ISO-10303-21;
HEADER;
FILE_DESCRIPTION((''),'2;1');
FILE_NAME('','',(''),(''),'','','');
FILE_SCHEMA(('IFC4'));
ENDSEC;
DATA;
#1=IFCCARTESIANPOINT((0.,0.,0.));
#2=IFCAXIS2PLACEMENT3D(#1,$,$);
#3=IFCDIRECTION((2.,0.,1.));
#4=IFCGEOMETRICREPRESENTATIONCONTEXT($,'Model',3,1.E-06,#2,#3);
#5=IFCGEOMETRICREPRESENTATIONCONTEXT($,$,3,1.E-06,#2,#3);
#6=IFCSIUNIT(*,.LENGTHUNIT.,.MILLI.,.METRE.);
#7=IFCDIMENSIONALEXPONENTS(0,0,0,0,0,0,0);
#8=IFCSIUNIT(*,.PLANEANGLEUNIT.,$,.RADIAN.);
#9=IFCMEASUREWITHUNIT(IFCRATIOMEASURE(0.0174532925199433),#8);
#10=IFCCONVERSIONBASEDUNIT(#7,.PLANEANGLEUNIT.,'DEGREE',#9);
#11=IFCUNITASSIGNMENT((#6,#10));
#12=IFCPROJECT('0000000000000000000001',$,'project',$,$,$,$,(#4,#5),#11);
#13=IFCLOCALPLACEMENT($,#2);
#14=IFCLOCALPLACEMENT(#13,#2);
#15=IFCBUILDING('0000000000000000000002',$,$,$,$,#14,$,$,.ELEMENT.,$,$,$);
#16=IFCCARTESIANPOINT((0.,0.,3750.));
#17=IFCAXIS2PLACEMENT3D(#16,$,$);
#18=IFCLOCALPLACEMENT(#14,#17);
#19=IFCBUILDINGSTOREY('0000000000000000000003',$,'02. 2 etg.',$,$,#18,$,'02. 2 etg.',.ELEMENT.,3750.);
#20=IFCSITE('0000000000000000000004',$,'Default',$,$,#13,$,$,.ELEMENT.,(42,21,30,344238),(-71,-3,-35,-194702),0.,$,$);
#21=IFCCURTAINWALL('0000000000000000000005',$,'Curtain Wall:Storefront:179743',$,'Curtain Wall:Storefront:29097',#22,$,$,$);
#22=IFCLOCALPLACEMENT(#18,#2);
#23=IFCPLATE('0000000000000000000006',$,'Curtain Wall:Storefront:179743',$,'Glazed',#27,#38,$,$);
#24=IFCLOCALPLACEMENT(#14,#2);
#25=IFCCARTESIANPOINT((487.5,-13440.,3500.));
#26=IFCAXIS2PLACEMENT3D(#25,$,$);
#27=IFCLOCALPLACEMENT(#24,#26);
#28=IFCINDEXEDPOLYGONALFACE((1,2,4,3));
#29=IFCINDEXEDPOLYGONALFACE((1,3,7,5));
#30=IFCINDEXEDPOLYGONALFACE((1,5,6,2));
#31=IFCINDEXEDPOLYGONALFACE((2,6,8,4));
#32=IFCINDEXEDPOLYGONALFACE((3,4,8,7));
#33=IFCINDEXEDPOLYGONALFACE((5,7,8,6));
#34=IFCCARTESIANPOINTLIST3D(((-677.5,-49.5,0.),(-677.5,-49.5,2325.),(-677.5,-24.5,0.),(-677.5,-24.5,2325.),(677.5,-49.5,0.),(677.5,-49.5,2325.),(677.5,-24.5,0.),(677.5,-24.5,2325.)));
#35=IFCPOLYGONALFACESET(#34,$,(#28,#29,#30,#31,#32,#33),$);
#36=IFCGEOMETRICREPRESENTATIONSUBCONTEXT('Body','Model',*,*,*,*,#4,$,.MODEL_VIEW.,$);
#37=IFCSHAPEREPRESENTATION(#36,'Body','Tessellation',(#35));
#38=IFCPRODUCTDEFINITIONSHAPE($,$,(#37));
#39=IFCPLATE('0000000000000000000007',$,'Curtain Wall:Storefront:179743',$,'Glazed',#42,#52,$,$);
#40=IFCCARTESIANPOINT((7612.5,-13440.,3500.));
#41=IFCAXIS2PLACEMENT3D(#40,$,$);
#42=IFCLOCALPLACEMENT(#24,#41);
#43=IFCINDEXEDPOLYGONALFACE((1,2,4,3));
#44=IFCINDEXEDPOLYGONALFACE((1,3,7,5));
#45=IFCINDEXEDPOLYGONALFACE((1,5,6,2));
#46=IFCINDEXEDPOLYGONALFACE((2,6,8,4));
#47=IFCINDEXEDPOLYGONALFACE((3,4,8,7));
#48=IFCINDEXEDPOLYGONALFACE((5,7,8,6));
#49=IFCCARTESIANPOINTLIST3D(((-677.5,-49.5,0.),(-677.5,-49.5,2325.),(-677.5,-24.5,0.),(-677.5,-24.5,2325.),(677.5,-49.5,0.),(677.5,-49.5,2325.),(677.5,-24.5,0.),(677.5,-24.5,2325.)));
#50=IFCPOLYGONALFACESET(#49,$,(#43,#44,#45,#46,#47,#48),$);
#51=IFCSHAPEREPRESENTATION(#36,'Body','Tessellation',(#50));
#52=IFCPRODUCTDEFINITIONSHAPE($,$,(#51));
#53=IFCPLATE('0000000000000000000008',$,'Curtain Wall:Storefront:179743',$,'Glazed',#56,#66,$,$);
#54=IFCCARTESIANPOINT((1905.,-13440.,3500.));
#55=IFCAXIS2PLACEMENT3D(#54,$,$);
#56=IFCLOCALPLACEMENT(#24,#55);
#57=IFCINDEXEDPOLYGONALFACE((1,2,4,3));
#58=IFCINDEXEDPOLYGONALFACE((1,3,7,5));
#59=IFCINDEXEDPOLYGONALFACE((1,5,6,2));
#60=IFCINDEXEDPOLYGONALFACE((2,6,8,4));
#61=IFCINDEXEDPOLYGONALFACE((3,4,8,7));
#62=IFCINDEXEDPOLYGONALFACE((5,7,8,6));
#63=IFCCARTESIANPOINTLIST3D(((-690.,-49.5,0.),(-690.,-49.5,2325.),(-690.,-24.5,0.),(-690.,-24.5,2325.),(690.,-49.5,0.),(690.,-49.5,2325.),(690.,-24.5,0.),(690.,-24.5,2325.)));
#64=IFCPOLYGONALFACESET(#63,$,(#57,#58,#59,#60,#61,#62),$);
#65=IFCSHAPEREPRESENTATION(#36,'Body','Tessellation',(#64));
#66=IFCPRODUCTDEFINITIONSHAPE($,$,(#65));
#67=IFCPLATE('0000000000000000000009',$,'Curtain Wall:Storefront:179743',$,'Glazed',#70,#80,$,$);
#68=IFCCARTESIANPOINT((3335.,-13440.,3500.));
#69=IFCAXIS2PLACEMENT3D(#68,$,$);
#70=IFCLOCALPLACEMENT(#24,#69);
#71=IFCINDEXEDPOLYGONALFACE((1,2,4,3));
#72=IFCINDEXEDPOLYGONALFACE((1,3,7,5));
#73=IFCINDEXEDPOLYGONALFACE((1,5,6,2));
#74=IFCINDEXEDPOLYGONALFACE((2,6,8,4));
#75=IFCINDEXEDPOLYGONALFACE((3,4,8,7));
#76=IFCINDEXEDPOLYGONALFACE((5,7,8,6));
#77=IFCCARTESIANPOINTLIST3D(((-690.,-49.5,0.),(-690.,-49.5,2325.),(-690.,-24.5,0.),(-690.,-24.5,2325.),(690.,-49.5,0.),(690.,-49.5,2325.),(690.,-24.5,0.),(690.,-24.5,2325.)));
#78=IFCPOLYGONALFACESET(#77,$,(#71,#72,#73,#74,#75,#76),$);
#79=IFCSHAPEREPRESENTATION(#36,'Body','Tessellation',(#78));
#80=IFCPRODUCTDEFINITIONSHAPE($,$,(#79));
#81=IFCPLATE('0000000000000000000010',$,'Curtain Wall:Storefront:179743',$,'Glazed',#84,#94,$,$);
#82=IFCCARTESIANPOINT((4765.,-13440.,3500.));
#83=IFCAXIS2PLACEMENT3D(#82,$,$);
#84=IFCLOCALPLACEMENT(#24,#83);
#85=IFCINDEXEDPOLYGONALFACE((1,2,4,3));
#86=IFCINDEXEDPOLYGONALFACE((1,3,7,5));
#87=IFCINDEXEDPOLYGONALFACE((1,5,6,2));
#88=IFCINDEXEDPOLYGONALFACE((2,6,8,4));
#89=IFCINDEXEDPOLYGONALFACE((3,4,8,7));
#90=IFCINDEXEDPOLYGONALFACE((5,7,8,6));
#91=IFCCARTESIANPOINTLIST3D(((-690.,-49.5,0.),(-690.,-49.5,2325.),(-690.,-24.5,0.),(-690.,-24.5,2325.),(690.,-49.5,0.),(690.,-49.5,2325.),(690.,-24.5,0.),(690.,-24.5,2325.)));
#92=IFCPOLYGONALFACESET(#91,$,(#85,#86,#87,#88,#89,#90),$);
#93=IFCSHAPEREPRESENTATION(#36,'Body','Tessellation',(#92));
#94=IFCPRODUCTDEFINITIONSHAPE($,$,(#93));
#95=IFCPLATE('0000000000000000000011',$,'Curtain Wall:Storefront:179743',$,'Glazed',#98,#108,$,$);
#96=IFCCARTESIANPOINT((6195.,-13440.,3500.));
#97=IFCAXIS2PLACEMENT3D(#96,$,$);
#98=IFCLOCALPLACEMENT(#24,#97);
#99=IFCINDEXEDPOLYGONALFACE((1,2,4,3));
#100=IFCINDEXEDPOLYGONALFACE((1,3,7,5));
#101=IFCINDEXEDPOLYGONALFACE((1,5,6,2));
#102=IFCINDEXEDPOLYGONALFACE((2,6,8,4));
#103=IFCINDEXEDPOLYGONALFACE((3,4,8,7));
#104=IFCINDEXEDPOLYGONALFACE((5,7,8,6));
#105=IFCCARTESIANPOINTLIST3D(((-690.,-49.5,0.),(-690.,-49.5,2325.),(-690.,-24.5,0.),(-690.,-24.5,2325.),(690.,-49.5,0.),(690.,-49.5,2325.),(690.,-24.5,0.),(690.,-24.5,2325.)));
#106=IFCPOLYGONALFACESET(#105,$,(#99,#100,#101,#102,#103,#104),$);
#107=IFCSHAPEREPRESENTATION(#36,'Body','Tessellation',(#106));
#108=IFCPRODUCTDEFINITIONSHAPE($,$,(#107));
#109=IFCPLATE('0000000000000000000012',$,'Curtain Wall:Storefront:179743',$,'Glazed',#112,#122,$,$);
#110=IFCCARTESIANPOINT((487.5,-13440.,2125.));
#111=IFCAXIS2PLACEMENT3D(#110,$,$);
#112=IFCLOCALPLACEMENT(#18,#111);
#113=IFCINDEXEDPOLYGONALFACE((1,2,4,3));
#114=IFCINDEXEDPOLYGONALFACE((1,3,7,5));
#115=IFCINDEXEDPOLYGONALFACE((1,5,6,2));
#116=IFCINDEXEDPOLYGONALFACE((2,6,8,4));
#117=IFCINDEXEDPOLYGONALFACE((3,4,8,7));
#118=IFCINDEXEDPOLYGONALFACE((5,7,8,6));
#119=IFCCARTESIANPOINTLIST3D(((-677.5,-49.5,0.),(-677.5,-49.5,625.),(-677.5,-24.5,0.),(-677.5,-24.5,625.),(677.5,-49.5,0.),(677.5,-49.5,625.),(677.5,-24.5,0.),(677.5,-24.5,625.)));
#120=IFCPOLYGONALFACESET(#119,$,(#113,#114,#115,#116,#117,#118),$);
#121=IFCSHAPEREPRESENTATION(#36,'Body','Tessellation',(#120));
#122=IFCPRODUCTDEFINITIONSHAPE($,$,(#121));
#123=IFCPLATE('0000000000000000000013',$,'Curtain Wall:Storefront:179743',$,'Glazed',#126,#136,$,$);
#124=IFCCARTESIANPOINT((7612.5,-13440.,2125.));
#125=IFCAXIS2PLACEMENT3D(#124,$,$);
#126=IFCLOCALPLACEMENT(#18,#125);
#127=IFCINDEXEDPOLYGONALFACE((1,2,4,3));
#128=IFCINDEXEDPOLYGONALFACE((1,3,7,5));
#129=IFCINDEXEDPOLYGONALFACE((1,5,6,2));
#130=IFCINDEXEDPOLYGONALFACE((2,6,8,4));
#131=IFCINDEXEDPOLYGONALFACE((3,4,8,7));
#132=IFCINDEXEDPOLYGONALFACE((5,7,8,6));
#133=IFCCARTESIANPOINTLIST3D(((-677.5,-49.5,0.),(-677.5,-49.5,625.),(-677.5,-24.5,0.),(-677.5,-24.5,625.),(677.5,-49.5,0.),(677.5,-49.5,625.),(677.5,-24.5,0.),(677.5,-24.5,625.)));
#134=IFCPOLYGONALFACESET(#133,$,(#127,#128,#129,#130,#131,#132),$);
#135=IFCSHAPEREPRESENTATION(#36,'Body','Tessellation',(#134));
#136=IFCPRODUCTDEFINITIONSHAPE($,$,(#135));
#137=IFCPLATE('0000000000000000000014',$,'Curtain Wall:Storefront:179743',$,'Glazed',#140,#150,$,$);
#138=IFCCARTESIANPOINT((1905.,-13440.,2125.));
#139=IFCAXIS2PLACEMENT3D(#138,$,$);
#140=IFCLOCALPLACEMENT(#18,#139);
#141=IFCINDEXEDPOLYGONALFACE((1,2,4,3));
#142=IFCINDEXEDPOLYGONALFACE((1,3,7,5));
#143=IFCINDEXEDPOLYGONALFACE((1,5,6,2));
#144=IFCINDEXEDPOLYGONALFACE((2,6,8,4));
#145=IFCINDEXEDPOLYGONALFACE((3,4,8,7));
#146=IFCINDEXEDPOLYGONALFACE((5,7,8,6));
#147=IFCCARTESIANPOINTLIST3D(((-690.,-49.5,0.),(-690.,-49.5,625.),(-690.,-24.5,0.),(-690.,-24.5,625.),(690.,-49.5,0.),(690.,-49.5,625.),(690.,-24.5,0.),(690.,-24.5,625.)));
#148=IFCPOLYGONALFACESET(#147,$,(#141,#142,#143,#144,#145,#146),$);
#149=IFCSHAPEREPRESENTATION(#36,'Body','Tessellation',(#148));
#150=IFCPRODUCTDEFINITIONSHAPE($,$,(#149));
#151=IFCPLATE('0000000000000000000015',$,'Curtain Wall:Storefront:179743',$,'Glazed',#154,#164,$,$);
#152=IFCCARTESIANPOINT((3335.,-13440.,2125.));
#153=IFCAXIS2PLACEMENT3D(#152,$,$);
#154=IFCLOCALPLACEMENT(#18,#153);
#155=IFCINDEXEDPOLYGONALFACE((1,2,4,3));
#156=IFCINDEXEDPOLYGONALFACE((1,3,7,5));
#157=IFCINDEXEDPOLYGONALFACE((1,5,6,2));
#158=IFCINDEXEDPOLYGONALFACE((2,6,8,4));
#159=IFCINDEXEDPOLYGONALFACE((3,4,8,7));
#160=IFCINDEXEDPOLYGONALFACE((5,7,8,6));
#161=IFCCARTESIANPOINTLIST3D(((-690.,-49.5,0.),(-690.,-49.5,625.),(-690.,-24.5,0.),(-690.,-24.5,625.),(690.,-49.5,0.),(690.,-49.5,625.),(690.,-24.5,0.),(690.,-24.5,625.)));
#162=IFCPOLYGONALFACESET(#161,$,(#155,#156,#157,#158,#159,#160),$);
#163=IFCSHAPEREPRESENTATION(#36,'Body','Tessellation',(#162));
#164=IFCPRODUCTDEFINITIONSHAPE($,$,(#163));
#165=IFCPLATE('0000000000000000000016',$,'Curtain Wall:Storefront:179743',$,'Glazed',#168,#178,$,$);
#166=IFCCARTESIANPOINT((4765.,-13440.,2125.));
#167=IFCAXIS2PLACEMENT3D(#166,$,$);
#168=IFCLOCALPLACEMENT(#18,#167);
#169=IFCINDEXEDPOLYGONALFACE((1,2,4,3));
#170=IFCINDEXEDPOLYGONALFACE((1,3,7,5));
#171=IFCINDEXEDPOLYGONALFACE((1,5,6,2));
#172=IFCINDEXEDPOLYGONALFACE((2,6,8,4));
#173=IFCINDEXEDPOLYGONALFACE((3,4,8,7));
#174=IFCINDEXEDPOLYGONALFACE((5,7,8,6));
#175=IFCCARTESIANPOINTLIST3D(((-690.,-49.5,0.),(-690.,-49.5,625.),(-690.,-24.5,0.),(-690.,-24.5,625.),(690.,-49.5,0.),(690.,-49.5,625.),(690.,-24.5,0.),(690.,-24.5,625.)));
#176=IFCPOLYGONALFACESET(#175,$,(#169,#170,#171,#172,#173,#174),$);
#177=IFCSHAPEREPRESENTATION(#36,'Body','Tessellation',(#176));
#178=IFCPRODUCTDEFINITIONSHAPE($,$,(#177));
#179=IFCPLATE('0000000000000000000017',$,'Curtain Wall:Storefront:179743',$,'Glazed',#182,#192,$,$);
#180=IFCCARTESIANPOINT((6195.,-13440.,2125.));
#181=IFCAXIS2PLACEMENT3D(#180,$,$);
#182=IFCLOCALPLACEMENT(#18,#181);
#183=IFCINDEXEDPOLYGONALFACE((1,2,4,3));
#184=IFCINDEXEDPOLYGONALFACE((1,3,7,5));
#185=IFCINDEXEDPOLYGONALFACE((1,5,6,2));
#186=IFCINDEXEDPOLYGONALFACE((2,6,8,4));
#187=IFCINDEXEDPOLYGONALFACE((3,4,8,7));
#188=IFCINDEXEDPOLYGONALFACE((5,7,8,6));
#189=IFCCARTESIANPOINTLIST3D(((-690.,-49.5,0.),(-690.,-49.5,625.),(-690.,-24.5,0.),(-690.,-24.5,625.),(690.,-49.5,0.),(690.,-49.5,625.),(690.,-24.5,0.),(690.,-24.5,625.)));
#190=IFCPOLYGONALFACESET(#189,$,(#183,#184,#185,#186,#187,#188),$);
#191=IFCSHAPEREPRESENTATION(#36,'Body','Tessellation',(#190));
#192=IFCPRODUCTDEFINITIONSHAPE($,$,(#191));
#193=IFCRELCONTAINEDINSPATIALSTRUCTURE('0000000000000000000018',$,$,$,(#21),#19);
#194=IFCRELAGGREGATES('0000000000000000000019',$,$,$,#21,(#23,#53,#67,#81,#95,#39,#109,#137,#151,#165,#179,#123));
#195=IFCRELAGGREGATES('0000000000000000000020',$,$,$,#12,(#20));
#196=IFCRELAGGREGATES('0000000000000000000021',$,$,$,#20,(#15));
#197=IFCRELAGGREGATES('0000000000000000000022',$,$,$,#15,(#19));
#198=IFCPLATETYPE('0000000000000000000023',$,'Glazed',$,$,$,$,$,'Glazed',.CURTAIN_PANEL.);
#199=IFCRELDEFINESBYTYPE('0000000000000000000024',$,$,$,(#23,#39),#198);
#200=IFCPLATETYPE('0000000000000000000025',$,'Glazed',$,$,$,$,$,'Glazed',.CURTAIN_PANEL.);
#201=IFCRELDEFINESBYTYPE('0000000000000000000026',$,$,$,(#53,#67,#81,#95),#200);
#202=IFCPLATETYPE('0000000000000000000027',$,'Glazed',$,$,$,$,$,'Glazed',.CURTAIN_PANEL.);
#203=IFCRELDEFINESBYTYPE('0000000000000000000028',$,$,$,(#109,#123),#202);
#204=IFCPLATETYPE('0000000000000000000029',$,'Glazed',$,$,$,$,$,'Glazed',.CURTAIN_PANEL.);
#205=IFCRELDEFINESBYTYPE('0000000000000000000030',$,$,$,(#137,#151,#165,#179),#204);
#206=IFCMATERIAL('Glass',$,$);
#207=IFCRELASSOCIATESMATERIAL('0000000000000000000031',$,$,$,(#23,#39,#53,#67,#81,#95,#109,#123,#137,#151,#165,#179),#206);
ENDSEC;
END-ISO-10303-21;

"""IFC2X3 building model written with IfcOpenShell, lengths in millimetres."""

from ifc_helpers import new_model, entity, si_unit, converted_unit, direction, frame, frame_2d, origin, place, context, subcontext, project, spatial, rectangle, extrude, source, transform, mapped, material, type_object, type_shapes, element, aggregate, save


model = new_model("IFC2X3")

# Units and contexts
model_context = context("Model", 3, precision=1e-06, world=origin(), true_north=direction((2.0, 0.0, 1.0)))
context_of_model = context(None, 3, precision=1e-06, world=origin(), true_north=direction((2.0, 0.0, 1.0)))
body_context = subcontext(model_context, "Body", "Model", "MODEL_VIEW")
ifc_project = project(units=[si_unit("LENGTHUNIT", "METRE", prefix="MILLI"), converted_unit("PLANEANGLEUNIT", "DEGREE", entity("IfcRatioMeasure", 0.0174532925199433), si_unit("PLANEANGLEUNIT", "RADIAN"), dimensions=[0, 0, 0, 0, 0, 0, 0])], contexts=[model_context, context_of_model])

# Site, building, storey
site_placement = place(None, origin())
site = spatial("IfcSite", under=ifc_project, at=site_placement, Name="Default", CompositionType="ELEMENT", RefLatitude=(42, 21, 30, 344238), RefLongitude=(-71, -3, -35, -194702), RefElevation=0.0)
building_placement = place(site_placement, origin())
building = spatial("IfcBuilding", under=site, at=building_placement, CompositionType="ELEMENT")
storey_placement = place(building_placement, frame((0.0, 0.0, 3750.0)))
storey = spatial("IfcBuildingStorey", under=building, at=storey_placement, Name="02. 2 etg.", LongName="02. 2 etg.", CompositionType="ELEMENT", Elevation=3750.0)

# Curtain wall, plates
curtain_wall_1_placement = place(storey_placement, origin())
curtain_wall_1 = element("IfcCurtainWall", 1, at=curtain_wall_1_placement, inside=storey, Name="Curtain Wall:Storefront:179743", ObjectType="Curtain Wall:Storefront:29097")
ifc_material_1 = material(Name="Glass")
plate_type_1 = type_object("IfcPlateType", Name="Glazed", ElementType="Glazed", PredefinedType="CURTAIN_PANEL")
shared_shape_1 = source(origin(), body_context, "Body", "SweptSolid", [
    extrude(rectangle(XDim=25.0, YDim=1355.0, at=frame_2d((0.0, 0.0), x_axis=(1.0, 0.0))), frame((0.0, -37.0, 0.0), z_axis=(0.0, 0.0, 1.0), x_axis=(0.0, 1.0, 0.0)), (0.0, 0.0, 1.0), 2325.0),
])
type_shapes(plate_type_1, [shared_shape_1])
placement = place(building_placement, origin())
plate_1_placement = place(placement, frame((487.5, -13440.0, 3500.0)))
plate_1 = element("IfcPlate", 2, at=plate_1_placement, type_object=plate_type_1, material=ifc_material_1, Name="Curtain Wall:Storefront:179743", ObjectType="Glazed", context=body_context, shape_type="MappedRepresentation", body=[
    mapped(shared_shape_1, transform((0.0, 0.0, 0.0), scale=1.0)),
])
plate_2_placement = place(placement, frame((7612.5, -13440.0, 3500.0)))
plate_2 = element("IfcPlate", 3, at=plate_2_placement, type_object=plate_type_1, material=ifc_material_1, Name="Curtain Wall:Storefront:179743", ObjectType="Glazed", context=body_context, shape_type="MappedRepresentation", body=[
    mapped(shared_shape_1, transform((0.0, 0.0, 0.0), scale=1.0)),
])
plate_type_2 = type_object("IfcPlateType", Name="Glazed", ElementType="Glazed", PredefinedType="CURTAIN_PANEL")
shared_shape_2 = source(origin(), body_context, "Body", "SweptSolid", [
    extrude(rectangle(XDim=25.0, YDim=1380.0, at=frame_2d((0.0, 0.0), x_axis=(1.0, 0.0))), frame((0.0, -37.0, 0.0), z_axis=(0.0, 0.0, 1.0), x_axis=(0.0, 1.0, 0.0)), (0.0, 0.0, 1.0), 2325.0),
])
type_shapes(plate_type_2, [shared_shape_2])
plate_3_placement = place(placement, frame((1905.0, -13440.0, 3500.0)))
plate_3 = element("IfcPlate", 4, at=plate_3_placement, type_object=plate_type_2, material=ifc_material_1, Name="Curtain Wall:Storefront:179743", ObjectType="Glazed", context=body_context, shape_type="MappedRepresentation", body=[
    mapped(shared_shape_2, transform((0.0, 0.0, 0.0), scale=1.0)),
])
plate_4_placement = place(placement, frame((3335.0, -13440.0, 3500.0)))
plate_4 = element("IfcPlate", 5, at=plate_4_placement, type_object=plate_type_2, material=ifc_material_1, Name="Curtain Wall:Storefront:179743", ObjectType="Glazed", context=body_context, shape_type="MappedRepresentation", body=[
    mapped(shared_shape_2, transform((0.0, 0.0, 0.0), scale=1.0)),
])
plate_5_placement = place(placement, frame((4765.0, -13440.0, 3500.0)))
plate_5 = element("IfcPlate", 6, at=plate_5_placement, type_object=plate_type_2, material=ifc_material_1, Name="Curtain Wall:Storefront:179743", ObjectType="Glazed", context=body_context, shape_type="MappedRepresentation", body=[
    mapped(shared_shape_2, transform((0.0, 0.0, 0.0), scale=1.0)),
])
plate_6_placement = place(placement, frame((6195.0, -13440.0, 3500.0)))
plate_6 = element("IfcPlate", 7, at=plate_6_placement, type_object=plate_type_2, material=ifc_material_1, Name="Curtain Wall:Storefront:179743", ObjectType="Glazed", context=body_context, shape_type="MappedRepresentation", body=[
    mapped(shared_shape_2, transform((0.0, 0.0, 0.0), scale=1.0)),
])
plate_type_3 = type_object("IfcPlateType", Name="Glazed", ElementType="Glazed", PredefinedType="CURTAIN_PANEL")
shared_shape_3 = source(origin(), body_context, "Body", "SweptSolid", [
    extrude(rectangle(XDim=25.0, YDim=1355.0, at=frame_2d((0.0, 0.0), x_axis=(1.0, 0.0))), frame((0.0, -37.0, 0.0), z_axis=(0.0, 0.0, 1.0), x_axis=(0.0, 1.0, 0.0)), (0.0, 0.0, 1.0), 625.0),
])
type_shapes(plate_type_3, [shared_shape_3])
plate_7_placement = place(storey_placement, frame((487.5, -13440.0, 2125.0)))
plate_7 = element("IfcPlate", 8, at=plate_7_placement, type_object=plate_type_3, material=ifc_material_1, Name="Curtain Wall:Storefront:179743", ObjectType="Glazed", context=body_context, shape_type="MappedRepresentation", body=[
    mapped(shared_shape_3, transform((0.0, 0.0, 0.0), scale=1.0)),
])
plate_8_placement = place(storey_placement, frame((7612.5, -13440.0, 2125.0)))
plate_8 = element("IfcPlate", 9, at=plate_8_placement, type_object=plate_type_3, material=ifc_material_1, Name="Curtain Wall:Storefront:179743", ObjectType="Glazed", context=body_context, shape_type="MappedRepresentation", body=[
    mapped(shared_shape_3, transform((0.0, 0.0, 0.0), scale=1.0)),
])
plate_type_4 = type_object("IfcPlateType", Name="Glazed", ElementType="Glazed", PredefinedType="CURTAIN_PANEL")
shared_shape_4 = source(origin(), body_context, "Body", "SweptSolid", [
    extrude(rectangle(XDim=25.0, YDim=1380.0, at=frame_2d((0.0, 0.0), x_axis=(1.0, 0.0))), frame((0.0, -37.0, 0.0), z_axis=(0.0, 0.0, 1.0), x_axis=(0.0, 1.0, 0.0)), (0.0, 0.0, 1.0), 625.0),
])
type_shapes(plate_type_4, [shared_shape_4])
plate_9_placement = place(storey_placement, frame((1905.0, -13440.0, 2125.0)))
plate_9 = element("IfcPlate", 10, at=plate_9_placement, type_object=plate_type_4, material=ifc_material_1, Name="Curtain Wall:Storefront:179743", ObjectType="Glazed", context=body_context, shape_type="MappedRepresentation", body=[
    mapped(shared_shape_4, transform((0.0, 0.0, 0.0), scale=1.0)),
])
plate_10_placement = place(storey_placement, frame((3335.0, -13440.0, 2125.0)))
plate_10 = element("IfcPlate", 11, at=plate_10_placement, type_object=plate_type_4, material=ifc_material_1, Name="Curtain Wall:Storefront:179743", ObjectType="Glazed", context=body_context, shape_type="MappedRepresentation", body=[
    mapped(shared_shape_4, transform((0.0, 0.0, 0.0), scale=1.0)),
])
plate_11_placement = place(storey_placement, frame((4765.0, -13440.0, 2125.0)))
plate_11 = element("IfcPlate", 12, at=plate_11_placement, type_object=plate_type_4, material=ifc_material_1, Name="Curtain Wall:Storefront:179743", ObjectType="Glazed", context=body_context, shape_type="MappedRepresentation", body=[
    mapped(shared_shape_4, transform((0.0, 0.0, 0.0), scale=1.0)),
])
plate_12_placement = place(storey_placement, frame((6195.0, -13440.0, 2125.0)))
plate_12 = element("IfcPlate", 13, at=plate_12_placement, type_object=plate_type_4, material=ifc_material_1, Name="Curtain Wall:Storefront:179743", ObjectType="Glazed", context=body_context, shape_type="MappedRepresentation", body=[
    mapped(shared_shape_4, transform((0.0, 0.0, 0.0), scale=1.0)),
])
aggregate(curtain_wall_1, [plate_1, plate_3, plate_4, plate_5, plate_6, plate_2, plate_7, plate_9, plate_10, plate_11, plate_12, plate_8])

save(model, "model.ifc")
